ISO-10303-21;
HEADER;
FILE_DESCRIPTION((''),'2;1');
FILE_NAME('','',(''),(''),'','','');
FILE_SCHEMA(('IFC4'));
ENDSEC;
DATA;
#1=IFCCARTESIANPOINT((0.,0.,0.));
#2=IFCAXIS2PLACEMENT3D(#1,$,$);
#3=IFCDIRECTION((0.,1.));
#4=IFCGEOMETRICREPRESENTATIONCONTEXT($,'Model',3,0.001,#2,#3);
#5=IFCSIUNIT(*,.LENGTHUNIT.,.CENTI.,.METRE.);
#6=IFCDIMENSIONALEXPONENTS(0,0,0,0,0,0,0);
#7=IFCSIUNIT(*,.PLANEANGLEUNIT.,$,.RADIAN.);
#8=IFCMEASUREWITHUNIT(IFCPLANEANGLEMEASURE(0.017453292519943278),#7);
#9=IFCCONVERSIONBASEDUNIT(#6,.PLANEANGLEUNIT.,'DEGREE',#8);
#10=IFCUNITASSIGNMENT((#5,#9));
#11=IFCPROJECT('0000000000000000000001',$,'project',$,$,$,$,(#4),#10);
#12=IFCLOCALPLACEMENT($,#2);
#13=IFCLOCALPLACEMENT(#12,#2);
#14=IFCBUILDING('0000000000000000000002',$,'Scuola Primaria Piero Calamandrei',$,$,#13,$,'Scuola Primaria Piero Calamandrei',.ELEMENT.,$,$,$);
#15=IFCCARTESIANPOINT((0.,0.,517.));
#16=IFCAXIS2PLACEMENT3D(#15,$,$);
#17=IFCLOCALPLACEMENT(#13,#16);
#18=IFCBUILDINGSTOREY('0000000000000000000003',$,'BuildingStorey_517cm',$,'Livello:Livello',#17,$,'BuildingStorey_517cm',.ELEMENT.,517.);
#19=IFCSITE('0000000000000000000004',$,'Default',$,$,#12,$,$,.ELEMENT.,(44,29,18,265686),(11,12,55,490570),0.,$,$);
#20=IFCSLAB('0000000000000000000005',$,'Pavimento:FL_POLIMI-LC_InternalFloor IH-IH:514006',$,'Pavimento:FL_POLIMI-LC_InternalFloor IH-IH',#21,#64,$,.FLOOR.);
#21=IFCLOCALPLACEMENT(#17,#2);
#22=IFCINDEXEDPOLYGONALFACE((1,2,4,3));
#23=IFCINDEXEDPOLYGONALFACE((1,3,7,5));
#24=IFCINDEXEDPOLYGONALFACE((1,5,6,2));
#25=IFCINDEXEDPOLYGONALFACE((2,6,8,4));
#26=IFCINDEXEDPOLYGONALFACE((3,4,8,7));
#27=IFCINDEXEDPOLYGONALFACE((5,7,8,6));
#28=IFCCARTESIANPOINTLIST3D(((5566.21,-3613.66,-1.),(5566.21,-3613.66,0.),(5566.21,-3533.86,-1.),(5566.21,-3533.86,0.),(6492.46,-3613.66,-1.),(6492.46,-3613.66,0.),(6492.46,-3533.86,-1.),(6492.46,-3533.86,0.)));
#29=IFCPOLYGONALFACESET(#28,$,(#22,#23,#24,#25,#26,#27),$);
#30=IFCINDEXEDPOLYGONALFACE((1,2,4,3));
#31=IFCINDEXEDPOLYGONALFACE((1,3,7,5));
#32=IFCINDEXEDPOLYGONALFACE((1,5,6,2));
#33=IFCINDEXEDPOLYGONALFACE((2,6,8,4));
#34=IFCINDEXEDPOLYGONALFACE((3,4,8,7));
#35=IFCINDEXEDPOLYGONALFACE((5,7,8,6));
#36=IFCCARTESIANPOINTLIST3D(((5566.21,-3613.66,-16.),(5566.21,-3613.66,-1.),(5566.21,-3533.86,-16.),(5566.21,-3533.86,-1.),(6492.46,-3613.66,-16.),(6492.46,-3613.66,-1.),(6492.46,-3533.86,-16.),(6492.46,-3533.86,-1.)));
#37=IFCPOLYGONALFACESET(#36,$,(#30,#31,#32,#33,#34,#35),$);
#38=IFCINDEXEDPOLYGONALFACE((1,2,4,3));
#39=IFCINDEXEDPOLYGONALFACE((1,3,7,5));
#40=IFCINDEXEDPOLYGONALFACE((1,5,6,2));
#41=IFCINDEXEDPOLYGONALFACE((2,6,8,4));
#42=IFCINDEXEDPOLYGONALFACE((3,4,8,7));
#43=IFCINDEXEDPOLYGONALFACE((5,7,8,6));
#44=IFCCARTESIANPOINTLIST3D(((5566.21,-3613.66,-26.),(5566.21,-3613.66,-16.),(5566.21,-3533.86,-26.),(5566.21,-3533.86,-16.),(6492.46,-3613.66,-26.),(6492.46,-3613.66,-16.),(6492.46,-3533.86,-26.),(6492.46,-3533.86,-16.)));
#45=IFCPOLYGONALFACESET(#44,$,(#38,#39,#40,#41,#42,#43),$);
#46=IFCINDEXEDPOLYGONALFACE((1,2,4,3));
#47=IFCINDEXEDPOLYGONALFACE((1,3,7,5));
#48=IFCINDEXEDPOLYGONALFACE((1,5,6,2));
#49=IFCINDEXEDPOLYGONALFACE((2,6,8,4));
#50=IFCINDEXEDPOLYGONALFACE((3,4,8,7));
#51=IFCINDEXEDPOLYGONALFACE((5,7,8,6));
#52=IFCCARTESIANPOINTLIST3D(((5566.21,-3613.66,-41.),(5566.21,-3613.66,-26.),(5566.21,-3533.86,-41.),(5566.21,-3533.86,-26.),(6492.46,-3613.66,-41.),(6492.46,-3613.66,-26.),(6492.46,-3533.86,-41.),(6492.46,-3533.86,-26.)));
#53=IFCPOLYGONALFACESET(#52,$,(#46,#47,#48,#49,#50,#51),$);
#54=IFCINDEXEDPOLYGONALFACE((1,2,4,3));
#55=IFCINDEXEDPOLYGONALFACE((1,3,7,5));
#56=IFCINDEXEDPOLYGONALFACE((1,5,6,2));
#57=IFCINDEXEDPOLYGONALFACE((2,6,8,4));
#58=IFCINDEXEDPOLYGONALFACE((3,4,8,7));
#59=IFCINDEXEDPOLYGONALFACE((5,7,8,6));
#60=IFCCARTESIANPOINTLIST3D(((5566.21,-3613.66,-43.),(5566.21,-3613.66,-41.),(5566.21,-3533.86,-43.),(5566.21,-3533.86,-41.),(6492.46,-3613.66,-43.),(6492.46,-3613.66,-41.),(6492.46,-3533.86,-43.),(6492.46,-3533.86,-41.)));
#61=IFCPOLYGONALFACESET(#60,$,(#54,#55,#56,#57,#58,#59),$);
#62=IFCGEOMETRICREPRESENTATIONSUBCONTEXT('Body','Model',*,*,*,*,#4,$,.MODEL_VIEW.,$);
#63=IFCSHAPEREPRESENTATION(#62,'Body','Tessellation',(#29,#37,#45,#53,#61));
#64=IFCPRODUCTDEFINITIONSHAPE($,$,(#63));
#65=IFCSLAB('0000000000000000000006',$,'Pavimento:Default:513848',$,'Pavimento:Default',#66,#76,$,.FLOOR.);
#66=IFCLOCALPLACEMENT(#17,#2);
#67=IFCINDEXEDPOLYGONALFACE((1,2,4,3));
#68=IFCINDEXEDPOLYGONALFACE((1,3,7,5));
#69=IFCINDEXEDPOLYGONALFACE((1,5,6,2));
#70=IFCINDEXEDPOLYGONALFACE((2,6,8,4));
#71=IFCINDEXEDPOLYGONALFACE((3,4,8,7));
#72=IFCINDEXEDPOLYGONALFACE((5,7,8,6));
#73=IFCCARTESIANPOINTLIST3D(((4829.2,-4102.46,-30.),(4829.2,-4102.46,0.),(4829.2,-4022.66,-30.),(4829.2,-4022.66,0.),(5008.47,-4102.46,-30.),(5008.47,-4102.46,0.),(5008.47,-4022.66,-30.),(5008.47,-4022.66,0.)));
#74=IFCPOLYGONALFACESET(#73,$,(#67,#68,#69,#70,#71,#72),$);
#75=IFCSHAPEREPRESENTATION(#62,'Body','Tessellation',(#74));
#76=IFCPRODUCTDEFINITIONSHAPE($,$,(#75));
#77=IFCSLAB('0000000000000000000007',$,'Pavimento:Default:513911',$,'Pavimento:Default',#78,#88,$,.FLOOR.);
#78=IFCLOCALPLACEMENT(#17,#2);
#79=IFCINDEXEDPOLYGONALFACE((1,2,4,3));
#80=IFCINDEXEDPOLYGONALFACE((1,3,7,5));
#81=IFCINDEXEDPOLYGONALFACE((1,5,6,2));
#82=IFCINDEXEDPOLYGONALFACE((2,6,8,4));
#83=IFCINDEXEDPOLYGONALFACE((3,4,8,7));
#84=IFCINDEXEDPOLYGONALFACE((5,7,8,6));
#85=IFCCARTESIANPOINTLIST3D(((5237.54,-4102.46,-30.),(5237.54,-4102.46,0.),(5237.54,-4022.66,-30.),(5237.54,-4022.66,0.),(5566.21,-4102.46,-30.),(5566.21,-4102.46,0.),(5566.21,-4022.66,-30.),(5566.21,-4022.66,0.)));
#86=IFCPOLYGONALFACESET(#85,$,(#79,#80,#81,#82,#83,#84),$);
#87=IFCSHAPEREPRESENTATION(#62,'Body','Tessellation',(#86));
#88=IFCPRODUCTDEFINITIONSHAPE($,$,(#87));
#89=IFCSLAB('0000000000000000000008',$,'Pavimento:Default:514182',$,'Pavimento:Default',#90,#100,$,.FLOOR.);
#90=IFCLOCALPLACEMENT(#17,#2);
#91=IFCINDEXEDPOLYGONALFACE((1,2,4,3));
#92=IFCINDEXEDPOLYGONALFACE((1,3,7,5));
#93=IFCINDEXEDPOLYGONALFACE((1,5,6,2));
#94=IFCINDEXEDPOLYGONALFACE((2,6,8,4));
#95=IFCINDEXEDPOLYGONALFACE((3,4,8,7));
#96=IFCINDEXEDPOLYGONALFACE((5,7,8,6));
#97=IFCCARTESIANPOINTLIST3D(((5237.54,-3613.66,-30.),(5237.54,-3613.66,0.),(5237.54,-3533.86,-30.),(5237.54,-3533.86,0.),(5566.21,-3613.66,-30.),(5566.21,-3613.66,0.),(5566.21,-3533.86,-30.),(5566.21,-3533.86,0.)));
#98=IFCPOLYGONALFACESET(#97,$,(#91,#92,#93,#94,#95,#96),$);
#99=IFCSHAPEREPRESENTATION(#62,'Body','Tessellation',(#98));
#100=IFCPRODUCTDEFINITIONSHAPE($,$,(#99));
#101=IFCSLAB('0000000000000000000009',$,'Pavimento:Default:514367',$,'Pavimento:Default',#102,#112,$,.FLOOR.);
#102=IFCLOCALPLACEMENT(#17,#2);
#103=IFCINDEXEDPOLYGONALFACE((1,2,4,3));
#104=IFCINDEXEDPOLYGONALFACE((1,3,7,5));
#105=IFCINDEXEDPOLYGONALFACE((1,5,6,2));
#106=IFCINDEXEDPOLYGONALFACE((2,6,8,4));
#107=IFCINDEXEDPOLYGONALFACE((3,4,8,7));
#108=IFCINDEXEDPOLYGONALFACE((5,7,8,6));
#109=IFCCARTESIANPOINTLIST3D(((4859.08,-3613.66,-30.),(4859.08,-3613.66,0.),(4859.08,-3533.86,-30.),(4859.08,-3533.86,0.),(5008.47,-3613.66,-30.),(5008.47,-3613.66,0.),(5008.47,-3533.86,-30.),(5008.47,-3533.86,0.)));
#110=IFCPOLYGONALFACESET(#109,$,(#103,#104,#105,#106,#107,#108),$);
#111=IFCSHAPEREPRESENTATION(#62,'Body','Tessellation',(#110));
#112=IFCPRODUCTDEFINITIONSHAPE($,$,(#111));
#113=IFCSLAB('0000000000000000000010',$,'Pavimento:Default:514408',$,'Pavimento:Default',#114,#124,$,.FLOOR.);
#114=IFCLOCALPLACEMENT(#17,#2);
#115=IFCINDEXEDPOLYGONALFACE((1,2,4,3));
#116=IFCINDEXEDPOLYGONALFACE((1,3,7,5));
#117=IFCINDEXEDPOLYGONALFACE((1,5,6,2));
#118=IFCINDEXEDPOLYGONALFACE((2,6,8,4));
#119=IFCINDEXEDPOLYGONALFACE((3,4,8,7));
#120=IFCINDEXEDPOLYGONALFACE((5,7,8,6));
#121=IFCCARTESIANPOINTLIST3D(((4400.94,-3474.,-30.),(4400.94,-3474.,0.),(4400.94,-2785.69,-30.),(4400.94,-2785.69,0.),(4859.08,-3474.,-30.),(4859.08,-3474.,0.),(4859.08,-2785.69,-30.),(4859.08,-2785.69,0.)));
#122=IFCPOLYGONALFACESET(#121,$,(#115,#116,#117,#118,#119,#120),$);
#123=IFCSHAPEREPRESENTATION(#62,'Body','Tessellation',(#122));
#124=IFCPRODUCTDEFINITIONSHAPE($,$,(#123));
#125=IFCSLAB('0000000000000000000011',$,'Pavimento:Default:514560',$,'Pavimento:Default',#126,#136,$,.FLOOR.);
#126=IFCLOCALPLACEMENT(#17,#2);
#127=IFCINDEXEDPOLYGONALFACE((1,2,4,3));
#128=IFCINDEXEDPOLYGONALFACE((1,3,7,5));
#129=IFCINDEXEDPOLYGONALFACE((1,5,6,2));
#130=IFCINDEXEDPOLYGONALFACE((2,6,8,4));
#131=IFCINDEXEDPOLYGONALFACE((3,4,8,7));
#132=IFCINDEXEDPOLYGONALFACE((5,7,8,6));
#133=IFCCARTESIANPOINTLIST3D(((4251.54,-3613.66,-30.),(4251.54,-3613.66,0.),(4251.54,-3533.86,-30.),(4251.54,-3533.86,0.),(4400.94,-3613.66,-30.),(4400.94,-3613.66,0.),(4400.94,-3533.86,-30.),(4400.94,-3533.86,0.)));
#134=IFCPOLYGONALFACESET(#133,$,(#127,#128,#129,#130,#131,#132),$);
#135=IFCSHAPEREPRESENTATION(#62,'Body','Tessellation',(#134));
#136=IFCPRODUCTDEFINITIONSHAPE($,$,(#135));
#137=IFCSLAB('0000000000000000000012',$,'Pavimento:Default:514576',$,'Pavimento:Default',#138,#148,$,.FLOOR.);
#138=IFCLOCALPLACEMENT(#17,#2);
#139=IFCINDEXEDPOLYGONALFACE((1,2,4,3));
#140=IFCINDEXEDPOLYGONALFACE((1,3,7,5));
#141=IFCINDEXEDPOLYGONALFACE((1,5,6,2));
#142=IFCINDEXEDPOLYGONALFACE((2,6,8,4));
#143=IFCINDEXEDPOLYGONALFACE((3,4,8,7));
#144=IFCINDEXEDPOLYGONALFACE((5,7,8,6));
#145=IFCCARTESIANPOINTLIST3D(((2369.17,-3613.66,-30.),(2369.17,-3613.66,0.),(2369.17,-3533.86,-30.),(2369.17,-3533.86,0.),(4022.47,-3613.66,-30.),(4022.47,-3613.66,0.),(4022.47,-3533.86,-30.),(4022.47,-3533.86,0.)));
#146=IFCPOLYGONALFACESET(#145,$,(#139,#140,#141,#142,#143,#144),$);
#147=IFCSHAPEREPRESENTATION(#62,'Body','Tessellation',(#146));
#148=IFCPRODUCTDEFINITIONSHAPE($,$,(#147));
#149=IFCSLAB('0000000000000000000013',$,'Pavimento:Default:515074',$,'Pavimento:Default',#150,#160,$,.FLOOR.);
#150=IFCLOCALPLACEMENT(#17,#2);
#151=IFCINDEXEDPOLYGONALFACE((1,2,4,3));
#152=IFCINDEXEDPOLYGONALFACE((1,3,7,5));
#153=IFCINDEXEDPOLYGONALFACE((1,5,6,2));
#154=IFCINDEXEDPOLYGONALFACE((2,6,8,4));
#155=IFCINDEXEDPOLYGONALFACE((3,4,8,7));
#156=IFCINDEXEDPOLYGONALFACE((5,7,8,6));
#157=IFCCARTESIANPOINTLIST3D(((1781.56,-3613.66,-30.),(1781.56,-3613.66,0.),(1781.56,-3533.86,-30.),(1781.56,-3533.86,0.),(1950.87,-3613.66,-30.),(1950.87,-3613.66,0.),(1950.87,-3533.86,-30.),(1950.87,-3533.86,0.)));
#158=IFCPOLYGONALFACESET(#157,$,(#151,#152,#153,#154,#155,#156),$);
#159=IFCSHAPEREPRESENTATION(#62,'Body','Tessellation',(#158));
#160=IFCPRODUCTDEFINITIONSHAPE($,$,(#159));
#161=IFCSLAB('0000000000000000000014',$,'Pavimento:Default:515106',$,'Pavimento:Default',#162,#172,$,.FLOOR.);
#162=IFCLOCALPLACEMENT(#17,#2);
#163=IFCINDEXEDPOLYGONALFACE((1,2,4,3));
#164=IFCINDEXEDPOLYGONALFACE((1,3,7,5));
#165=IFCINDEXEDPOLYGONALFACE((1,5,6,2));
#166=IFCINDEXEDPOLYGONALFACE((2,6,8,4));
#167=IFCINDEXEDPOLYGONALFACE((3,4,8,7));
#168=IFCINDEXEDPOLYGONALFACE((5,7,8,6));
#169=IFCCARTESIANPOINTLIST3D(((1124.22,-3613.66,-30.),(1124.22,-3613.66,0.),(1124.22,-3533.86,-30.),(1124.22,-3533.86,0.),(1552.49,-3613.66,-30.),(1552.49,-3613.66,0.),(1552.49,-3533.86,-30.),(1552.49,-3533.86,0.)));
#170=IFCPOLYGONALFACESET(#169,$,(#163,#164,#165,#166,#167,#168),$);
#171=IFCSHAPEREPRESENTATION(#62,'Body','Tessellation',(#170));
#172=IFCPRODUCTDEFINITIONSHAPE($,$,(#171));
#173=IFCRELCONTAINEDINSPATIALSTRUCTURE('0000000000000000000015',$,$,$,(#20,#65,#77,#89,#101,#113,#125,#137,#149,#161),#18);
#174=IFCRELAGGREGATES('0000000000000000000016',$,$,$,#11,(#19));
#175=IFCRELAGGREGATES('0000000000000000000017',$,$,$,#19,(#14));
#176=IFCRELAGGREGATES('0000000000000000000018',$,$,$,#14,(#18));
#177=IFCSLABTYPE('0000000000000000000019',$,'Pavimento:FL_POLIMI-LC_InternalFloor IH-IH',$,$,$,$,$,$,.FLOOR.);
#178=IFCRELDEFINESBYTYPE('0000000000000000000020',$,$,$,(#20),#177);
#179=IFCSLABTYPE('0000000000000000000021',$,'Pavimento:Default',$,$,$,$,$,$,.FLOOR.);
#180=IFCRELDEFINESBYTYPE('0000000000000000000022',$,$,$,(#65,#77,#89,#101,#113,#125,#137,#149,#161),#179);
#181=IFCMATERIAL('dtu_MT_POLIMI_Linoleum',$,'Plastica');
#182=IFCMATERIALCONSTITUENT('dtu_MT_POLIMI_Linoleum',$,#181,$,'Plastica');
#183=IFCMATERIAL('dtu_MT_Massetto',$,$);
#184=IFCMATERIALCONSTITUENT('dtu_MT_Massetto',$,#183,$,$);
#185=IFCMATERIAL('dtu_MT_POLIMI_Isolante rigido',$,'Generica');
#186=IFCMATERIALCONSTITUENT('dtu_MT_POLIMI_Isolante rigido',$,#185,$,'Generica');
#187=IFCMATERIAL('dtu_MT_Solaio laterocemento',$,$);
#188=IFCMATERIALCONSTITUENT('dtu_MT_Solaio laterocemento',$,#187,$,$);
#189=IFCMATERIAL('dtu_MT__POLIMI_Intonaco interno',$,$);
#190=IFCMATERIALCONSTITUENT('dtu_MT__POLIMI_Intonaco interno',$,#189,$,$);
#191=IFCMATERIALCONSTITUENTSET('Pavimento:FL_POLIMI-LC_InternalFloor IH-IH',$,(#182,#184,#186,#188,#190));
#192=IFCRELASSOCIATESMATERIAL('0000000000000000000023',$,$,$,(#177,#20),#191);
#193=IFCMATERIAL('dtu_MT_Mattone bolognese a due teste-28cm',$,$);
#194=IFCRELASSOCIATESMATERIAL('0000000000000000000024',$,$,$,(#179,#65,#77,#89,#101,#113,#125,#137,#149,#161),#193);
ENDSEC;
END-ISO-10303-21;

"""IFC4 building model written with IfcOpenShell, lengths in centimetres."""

from ifc_helpers import new_model, entity, si_unit, converted_unit, direction, frame, origin, place, context, subcontext, project, spatial, indexed_curve, outline, extrude, material, constituent, constituent_set, type_object, element, save


model = new_model("IFC4")

# Units and contexts
model_context = context("Model", 3, precision=0.001, world=origin(), true_north=direction((0.0, 1.0)))
body_context = subcontext(model_context, "Body", "Model", "MODEL_VIEW")
ifc_project = project(units=[si_unit("LENGTHUNIT", "METRE", prefix="CENTI"), converted_unit("PLANEANGLEUNIT", "DEGREE", entity("IfcPlaneAngleMeasure", 0.017453292519943278), si_unit("PLANEANGLEUNIT", "RADIAN"), dimensions=[0, 0, 0, 0, 0, 0, 0])], contexts=[model_context])

# Site, building, storey
site_placement = place(None, origin())
site = spatial("IfcSite", under=ifc_project, at=site_placement, Name="Default", CompositionType="ELEMENT", RefLatitude=(44, 29, 18, 265686), RefLongitude=(11, 12, 55, 490570), RefElevation=0.0)
building_placement = place(site_placement, origin())
building = spatial("IfcBuilding", under=site, at=building_placement, Name="Scuola Primaria Piero Calamandrei", LongName="Scuola Primaria Piero Calamandrei", CompositionType="ELEMENT")
storey_placement = place(building_placement, frame((0.0, 0.0, 517.0)))
storey = spatial("IfcBuildingStorey", under=building, at=storey_placement, Name="BuildingStorey_517cm", ObjectType="Livello:Livello", LongName="BuildingStorey_517cm", CompositionType="ELEMENT", Elevation=517.0)

# Slabs
ifc_material_1 = material(Name="dtu_MT_POLIMI_Linoleum", Category="Plastica")
ifc_constituent_1 = constituent(ifc_material_1, Name="dtu_MT_POLIMI_Linoleum", Category="Plastica")
ifc_material_2 = material(Name="dtu_MT_Massetto")
ifc_constituent_2 = constituent(ifc_material_2, Name="dtu_MT_Massetto")
ifc_material_3 = material(Name="dtu_MT_POLIMI_Isolante rigido", Category="Generica")
ifc_constituent_3 = constituent(ifc_material_3, Name="dtu_MT_POLIMI_Isolante rigido", Category="Generica")
ifc_material_4 = material(Name="dtu_MT_Solaio laterocemento")
ifc_constituent_4 = constituent(ifc_material_4, Name="dtu_MT_Solaio laterocemento")
ifc_material_5 = material(Name="dtu_MT__POLIMI_Intonaco interno")
ifc_constituent_5 = constituent(ifc_material_5, Name="dtu_MT__POLIMI_Intonaco interno")
ifc_constituent_set_1 = constituent_set(constituents=[ifc_constituent_1, ifc_constituent_2, ifc_constituent_3, ifc_constituent_4, ifc_constituent_5], Name="Pavimento:FL_POLIMI-LC_InternalFloor IH-IH")
slab_type_1 = type_object("IfcSlabType", Name="Pavimento:FL_POLIMI-LC_InternalFloor IH-IH", PredefinedType="FLOOR", material=ifc_constituent_set_1)
slab_1_placement = place(storey_placement, origin())
element("IfcSlab", 1, at=slab_1_placement, inside=storey, type_object=slab_type_1, material=ifc_constituent_set_1, Name="Pavimento:FL_POLIMI-LC_InternalFloor IH-IH:514006", ObjectType="Pavimento:FL_POLIMI-LC_InternalFloor IH-IH", PredefinedType="FLOOR", context=body_context, shape_type="SweptSolid", body=[
    extrude(outline(indexed_curve([(-39.9, -463.12), (39.9, -463.12), (39.9, 463.12), (-39.9, 463.12), (-39.9, -463.12)], self_intersect=False)), frame((6029.33, -3573.76, -1.0), z_axis=(0.0, 0.0, 1.0), x_axis=(0.0, 1.0, 0.0)), (0.0, 0.0, 1.0), 1.0),
    extrude(outline(indexed_curve([(-39.9, -463.12), (39.9, -463.12), (39.9, 463.12), (-39.9, 463.12), (-39.9, -463.12)], self_intersect=False)), frame((6029.33, -3573.76, -16.0), z_axis=(0.0, 0.0, 1.0), x_axis=(0.0, 1.0, 0.0)), (0.0, 0.0, 1.0), 15.0),
    extrude(outline(indexed_curve([(-39.9, -463.12), (39.9, -463.12), (39.9, 463.12), (-39.9, 463.12), (-39.9, -463.12)], self_intersect=False)), frame((6029.33, -3573.76, -26.0), z_axis=(0.0, 0.0, 1.0), x_axis=(0.0, 1.0, 0.0)), (0.0, 0.0, 1.0), 10.0),
    extrude(outline(indexed_curve([(-39.9, -463.12), (39.9, -463.12), (39.9, 463.12), (-39.9, 463.12), (-39.9, -463.12)], self_intersect=False)), frame((6029.33, -3573.76, -41.0), z_axis=(0.0, 0.0, 1.0), x_axis=(0.0, 1.0, 0.0)), (0.0, 0.0, 1.0), 15.0),
    extrude(outline(indexed_curve([(-39.9, -463.12), (39.9, -463.12), (39.9, 463.12), (-39.9, 463.12), (-39.9, -463.12)], self_intersect=False)), frame((6029.33, -3573.76, -43.0), z_axis=(0.0, 0.0, 1.0), x_axis=(0.0, 1.0, 0.0)), (0.0, 0.0, 1.0), 2.0),
])
ifc_material_6 = material(Name="dtu_MT_Mattone bolognese a due teste-28cm")
slab_type_2 = type_object("IfcSlabType", Name="Pavimento:Default", PredefinedType="FLOOR", material=ifc_material_6)
slab_2_placement = place(storey_placement, origin())
element("IfcSlab", 2, at=slab_2_placement, inside=storey, type_object=slab_type_2, material=ifc_material_6, Name="Pavimento:Default:513848", ObjectType="Pavimento:Default", PredefinedType="FLOOR", context=body_context, shape_type="SweptSolid", body=[
    extrude(outline(indexed_curve([(-39.9, -89.64), (39.9, -89.64), (39.9, 89.64), (-39.9, 89.64), (-39.9, -89.64)], self_intersect=False)), frame((4918.84, -4062.56, 0.0), z_axis=(0.0, 0.0, -1.0), x_axis=(0.0, 1.0, 0.0)), (0.0, 0.0, 1.0), 30.0),
])
slab_3_placement = place(storey_placement, origin())
element("IfcSlab", 3, at=slab_3_placement, inside=storey, type_object=slab_type_2, material=ifc_material_6, Name="Pavimento:Default:513911", ObjectType="Pavimento:Default", PredefinedType="FLOOR", context=body_context, shape_type="SweptSolid", body=[
    extrude(outline(indexed_curve([(-39.9, -164.33), (39.9, -164.33), (39.9, 164.33), (-39.9, 164.33), (-39.9, -164.33)], self_intersect=False)), frame((5401.88, -4062.56, 0.0), z_axis=(0.0, 0.0, -1.0), x_axis=(0.0, 1.0, 0.0)), (0.0, 0.0, 1.0), 30.0),
])
slab_4_placement = place(storey_placement, origin())
element("IfcSlab", 4, at=slab_4_placement, inside=storey, type_object=slab_type_2, material=ifc_material_6, Name="Pavimento:Default:514182", ObjectType="Pavimento:Default", PredefinedType="FLOOR", context=body_context, shape_type="SweptSolid", body=[
    extrude(outline(indexed_curve([(-39.9, -164.33), (39.9, -164.33), (39.9, 164.33), (-39.9, 164.33), (-39.9, -164.33)], self_intersect=False)), frame((5401.88, -3573.76, 0.0), z_axis=(0.0, 0.0, -1.0), x_axis=(0.0, 1.0, 0.0)), (0.0, 0.0, 1.0), 30.0),
])
slab_5_placement = place(storey_placement, origin())
element("IfcSlab", 5, at=slab_5_placement, inside=storey, type_object=slab_type_2, material=ifc_material_6, Name="Pavimento:Default:514367", ObjectType="Pavimento:Default", PredefinedType="FLOOR", context=body_context, shape_type="SweptSolid", body=[
    extrude(outline(indexed_curve([(-39.9, -74.7), (39.9, -74.7), (39.9, 74.7), (-39.9, 74.7), (-39.9, -74.7)], self_intersect=False)), frame((4933.78, -3573.76, 0.0), z_axis=(0.0, 0.0, -1.0), x_axis=(0.0, 1.0, 0.0)), (0.0, 0.0, 1.0), 30.0),
])
slab_6_placement = place(storey_placement, origin())
element("IfcSlab", 6, at=slab_6_placement, inside=storey, type_object=slab_type_2, material=ifc_material_6, Name="Pavimento:Default:514408", ObjectType="Pavimento:Default", PredefinedType="FLOOR", context=body_context, shape_type="SweptSolid", body=[
    extrude(outline(indexed_curve([(-344.16, -229.07), (344.16, -229.07), (344.16, 229.07), (-344.16, 229.07), (-344.16, -229.07)], self_intersect=False)), frame((4630.01, -3129.85, 0.0), z_axis=(0.0, 0.0, -1.0), x_axis=(0.0, 1.0, 0.0)), (0.0, 0.0, 1.0), 30.0),
])
slab_7_placement = place(storey_placement, origin())
element("IfcSlab", 7, at=slab_7_placement, inside=storey, type_object=slab_type_2, material=ifc_material_6, Name="Pavimento:Default:514560", ObjectType="Pavimento:Default", PredefinedType="FLOOR", context=body_context, shape_type="SweptSolid", body=[
    extrude(outline(indexed_curve([(-39.9, -74.7), (39.9, -74.7), (39.9, 74.7), (-39.9, 74.7), (-39.9, -74.7)], self_intersect=False)), frame((4326.24, -3573.76, 0.0), z_axis=(0.0, 0.0, -1.0), x_axis=(0.0, 1.0, 0.0)), (0.0, 0.0, 1.0), 30.0),
])
slab_8_placement = place(storey_placement, origin())
element("IfcSlab", 8, at=slab_8_placement, inside=storey, type_object=slab_type_2, material=ifc_material_6, Name="Pavimento:Default:514576", ObjectType="Pavimento:Default", PredefinedType="FLOOR", context=body_context, shape_type="SweptSolid", body=[
    extrude(outline(indexed_curve([(-39.9, -826.65), (39.9, -826.65), (39.9, 826.65), (-39.9, 826.65), (-39.9, -826.65)], self_intersect=False)), frame((3195.82, -3573.76, 0.0), z_axis=(0.0, 0.0, -1.0), x_axis=(0.0, 1.0, 0.0)), (0.0, 0.0, 1.0), 30.0),
])
slab_9_placement = place(storey_placement, origin())
element("IfcSlab", 9, at=slab_9_placement, inside=storey, type_object=slab_type_2, material=ifc_material_6, Name="Pavimento:Default:515074", ObjectType="Pavimento:Default", PredefinedType="FLOOR", context=body_context, shape_type="SweptSolid", body=[
    extrude(outline(indexed_curve([(-39.9, -84.66), (39.9, -84.66), (39.9, 84.66), (-39.9, 84.66), (-39.9, -84.66)], self_intersect=False)), frame((1866.21, -3573.76, 0.0), z_axis=(0.0, 0.0, -1.0), x_axis=(0.0, 1.0, 0.0)), (0.0, 0.0, 1.0), 30.0),
])
slab_10_placement = place(storey_placement, origin())
element("IfcSlab", 10, at=slab_10_placement, inside=storey, type_object=slab_type_2, material=ifc_material_6, Name="Pavimento:Default:515106", ObjectType="Pavimento:Default", PredefinedType="FLOOR", context=body_context, shape_type="SweptSolid", body=[
    extrude(outline(indexed_curve([(-39.9, -214.13), (39.9, -214.13), (39.9, 214.13), (-39.9, 214.13), (-39.9, -214.13)], self_intersect=False)), frame((1338.35, -3573.76, 0.0), z_axis=(0.0, 0.0, -1.0), x_axis=(0.0, 1.0, 0.0)), (0.0, 0.0, 1.0), 30.0),
])

save(model, "model.ifc")
